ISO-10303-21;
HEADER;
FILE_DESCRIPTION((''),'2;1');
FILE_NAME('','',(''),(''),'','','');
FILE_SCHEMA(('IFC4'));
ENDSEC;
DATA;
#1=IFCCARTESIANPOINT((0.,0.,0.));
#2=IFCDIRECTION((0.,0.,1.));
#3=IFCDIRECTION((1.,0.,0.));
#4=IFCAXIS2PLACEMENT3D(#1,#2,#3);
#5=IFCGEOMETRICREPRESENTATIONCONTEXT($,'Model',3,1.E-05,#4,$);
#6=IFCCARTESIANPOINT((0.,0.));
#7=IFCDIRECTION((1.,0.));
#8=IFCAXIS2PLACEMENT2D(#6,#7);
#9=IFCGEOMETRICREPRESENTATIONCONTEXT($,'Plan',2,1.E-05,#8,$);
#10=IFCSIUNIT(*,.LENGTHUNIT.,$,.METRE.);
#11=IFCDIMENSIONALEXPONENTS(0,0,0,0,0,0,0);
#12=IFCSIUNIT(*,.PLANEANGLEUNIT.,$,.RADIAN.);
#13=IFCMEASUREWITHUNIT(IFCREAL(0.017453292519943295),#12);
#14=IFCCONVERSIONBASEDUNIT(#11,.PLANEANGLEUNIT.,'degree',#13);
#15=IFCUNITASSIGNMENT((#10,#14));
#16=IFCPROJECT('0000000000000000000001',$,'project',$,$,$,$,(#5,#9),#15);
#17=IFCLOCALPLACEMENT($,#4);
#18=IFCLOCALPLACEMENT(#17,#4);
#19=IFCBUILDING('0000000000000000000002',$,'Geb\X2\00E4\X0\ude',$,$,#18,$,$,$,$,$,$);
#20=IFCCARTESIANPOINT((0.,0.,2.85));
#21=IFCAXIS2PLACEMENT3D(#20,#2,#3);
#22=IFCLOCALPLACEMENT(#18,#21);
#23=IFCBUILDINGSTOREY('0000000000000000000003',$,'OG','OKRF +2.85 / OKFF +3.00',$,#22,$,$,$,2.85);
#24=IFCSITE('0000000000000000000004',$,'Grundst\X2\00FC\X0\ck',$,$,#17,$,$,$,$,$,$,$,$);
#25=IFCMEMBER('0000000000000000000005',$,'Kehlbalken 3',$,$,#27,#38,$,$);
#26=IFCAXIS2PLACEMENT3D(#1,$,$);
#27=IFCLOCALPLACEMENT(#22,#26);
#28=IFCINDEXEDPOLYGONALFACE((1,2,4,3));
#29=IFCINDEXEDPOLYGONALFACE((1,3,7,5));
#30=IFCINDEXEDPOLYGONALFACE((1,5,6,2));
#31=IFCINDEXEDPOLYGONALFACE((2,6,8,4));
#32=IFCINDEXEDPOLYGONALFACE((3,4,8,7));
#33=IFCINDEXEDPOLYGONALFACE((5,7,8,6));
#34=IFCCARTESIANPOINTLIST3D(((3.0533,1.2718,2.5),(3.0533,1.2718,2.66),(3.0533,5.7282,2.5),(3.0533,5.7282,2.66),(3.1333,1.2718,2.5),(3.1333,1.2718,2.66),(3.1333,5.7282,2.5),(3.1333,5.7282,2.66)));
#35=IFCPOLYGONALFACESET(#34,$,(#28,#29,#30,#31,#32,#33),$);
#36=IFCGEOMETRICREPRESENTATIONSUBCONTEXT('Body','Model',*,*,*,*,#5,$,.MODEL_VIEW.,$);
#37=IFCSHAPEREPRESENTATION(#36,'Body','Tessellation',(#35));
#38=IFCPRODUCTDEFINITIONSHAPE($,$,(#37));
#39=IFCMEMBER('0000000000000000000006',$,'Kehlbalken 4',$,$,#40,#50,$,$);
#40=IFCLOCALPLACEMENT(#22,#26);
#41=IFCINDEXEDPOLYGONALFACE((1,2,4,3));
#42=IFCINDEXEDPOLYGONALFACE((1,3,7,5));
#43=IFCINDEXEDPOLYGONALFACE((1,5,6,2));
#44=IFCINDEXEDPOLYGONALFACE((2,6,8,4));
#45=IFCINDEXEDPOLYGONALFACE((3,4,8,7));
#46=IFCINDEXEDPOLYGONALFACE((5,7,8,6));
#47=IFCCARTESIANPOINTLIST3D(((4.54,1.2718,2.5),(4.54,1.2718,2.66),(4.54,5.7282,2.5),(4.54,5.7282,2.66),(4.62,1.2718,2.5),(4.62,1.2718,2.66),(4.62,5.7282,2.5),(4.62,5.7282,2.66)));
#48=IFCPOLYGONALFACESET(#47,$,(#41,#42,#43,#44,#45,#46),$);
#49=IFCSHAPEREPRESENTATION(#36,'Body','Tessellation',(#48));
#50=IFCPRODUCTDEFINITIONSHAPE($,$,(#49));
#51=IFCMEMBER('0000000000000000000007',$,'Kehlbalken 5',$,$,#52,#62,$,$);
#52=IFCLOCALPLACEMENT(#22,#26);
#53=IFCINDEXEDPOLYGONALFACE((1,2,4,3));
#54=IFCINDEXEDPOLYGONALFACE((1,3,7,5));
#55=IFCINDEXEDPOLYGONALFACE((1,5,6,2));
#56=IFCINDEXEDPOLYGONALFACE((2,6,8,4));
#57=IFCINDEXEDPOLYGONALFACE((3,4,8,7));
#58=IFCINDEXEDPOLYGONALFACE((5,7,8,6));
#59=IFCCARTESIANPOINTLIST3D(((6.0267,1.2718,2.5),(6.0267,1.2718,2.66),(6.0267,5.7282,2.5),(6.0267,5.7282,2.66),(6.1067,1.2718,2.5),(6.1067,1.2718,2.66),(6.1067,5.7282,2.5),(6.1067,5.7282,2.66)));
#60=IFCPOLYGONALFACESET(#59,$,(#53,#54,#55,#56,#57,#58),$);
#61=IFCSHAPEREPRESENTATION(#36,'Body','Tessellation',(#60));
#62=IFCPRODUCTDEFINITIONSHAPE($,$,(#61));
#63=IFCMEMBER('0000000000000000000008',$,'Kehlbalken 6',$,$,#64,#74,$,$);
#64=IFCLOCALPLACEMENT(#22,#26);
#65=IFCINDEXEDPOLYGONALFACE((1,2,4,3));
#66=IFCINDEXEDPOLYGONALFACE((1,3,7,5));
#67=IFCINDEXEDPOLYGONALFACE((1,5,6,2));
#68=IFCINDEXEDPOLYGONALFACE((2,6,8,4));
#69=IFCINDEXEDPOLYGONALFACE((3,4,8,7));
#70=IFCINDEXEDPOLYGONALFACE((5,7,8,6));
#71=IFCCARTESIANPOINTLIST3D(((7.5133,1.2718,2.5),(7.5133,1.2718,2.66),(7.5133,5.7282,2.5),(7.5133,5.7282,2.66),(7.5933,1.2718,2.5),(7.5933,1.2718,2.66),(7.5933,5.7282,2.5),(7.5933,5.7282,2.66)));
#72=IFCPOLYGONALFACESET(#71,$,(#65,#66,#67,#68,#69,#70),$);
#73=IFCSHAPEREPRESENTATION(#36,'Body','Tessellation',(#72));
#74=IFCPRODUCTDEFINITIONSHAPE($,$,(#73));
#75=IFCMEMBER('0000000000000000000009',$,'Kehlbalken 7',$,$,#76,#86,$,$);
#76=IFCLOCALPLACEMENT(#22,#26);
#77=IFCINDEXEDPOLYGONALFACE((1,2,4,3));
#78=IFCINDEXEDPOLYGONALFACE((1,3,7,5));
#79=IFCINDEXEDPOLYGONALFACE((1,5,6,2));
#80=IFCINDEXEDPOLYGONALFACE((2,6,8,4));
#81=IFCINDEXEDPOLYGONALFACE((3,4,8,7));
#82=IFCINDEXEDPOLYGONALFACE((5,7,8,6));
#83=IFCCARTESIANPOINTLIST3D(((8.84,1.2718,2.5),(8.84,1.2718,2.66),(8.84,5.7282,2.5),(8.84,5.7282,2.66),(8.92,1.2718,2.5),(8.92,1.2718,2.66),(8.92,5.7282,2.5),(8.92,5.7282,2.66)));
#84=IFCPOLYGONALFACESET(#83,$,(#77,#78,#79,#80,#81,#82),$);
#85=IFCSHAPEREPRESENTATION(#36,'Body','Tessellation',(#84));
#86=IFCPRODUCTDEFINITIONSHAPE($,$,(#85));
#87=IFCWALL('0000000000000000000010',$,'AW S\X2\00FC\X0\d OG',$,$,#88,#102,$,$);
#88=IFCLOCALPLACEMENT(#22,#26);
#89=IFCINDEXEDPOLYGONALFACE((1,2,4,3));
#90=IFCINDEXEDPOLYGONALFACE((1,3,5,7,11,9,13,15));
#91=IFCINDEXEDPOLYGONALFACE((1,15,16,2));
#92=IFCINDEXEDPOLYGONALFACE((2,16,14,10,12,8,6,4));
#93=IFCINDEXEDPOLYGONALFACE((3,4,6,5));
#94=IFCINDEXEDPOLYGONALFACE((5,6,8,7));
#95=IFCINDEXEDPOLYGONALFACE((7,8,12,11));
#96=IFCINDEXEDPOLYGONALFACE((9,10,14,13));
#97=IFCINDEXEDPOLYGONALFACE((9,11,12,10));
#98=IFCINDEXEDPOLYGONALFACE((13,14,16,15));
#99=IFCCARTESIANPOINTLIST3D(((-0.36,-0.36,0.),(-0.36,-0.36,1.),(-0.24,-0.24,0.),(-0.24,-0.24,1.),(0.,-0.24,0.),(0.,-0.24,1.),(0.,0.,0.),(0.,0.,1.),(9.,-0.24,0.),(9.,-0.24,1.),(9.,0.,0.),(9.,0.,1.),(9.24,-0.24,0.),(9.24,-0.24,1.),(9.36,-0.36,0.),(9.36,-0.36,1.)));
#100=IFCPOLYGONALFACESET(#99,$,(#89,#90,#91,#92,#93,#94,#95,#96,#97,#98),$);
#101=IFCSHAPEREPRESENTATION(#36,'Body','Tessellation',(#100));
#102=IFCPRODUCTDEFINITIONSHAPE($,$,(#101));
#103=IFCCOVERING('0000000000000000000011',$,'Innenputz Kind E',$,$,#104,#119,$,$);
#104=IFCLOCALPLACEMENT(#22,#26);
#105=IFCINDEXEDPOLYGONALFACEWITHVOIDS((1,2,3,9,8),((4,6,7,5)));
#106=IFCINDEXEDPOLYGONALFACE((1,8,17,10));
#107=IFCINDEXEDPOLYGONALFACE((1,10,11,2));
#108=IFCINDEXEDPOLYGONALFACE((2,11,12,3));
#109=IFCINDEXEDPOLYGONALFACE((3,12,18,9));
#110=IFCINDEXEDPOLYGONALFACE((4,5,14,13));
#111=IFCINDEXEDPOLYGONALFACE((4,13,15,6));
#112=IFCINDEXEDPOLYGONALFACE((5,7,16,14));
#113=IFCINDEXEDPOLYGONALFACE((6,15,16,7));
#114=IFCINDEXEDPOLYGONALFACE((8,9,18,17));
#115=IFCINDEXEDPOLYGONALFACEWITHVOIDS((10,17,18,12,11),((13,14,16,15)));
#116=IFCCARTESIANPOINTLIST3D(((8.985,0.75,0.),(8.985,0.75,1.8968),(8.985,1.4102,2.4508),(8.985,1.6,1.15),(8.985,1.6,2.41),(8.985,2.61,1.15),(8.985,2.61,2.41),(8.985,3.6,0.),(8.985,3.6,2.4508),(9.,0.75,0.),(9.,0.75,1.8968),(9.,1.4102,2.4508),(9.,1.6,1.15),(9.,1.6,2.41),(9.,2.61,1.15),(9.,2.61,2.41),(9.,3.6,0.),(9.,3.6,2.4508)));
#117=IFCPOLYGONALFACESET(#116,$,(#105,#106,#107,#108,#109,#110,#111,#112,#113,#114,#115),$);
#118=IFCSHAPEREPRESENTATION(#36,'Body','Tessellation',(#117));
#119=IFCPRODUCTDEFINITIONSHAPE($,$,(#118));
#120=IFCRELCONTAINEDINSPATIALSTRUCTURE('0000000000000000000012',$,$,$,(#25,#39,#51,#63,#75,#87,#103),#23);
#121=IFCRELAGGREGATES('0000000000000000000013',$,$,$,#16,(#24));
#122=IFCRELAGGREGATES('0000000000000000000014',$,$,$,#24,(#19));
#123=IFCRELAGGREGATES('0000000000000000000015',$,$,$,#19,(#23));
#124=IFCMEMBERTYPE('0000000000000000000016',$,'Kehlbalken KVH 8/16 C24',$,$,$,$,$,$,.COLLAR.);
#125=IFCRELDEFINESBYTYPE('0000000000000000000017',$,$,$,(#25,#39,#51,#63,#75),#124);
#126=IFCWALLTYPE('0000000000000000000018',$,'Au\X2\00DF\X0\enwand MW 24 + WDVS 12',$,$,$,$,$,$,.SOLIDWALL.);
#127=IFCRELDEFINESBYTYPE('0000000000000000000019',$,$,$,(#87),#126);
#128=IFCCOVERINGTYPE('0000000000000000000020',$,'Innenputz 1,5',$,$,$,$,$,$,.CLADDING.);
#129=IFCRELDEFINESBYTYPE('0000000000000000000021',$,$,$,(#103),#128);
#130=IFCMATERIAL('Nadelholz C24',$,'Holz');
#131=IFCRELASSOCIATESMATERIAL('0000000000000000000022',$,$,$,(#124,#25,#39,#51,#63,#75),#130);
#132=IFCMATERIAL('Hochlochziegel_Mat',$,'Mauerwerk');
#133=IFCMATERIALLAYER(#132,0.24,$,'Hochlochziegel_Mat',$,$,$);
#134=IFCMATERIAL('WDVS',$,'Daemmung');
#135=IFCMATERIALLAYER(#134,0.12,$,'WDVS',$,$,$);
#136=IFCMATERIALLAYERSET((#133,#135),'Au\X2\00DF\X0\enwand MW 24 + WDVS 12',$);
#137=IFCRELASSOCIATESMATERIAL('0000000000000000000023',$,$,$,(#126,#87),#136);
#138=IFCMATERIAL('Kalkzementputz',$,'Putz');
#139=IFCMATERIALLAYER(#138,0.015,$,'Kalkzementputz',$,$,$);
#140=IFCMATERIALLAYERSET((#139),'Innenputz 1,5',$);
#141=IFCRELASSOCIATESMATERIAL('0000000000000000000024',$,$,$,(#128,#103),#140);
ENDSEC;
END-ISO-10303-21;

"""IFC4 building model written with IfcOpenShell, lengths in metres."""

from ifc_helpers import new_model, entity, si_unit, converted_unit, frame, origin_with_axes, origin_2d_with_axis, place, context, subcontext, project, spatial, line, indexed_curve, rectangle, outline, extrude, clip, halfspace, material, layer, layer_set, layer_usage, material_profile, profile_set, profile_usage, type_object, element, save


model = new_model("IFC4")

# Units and contexts
model_context = context("Model", 3, precision=1e-05, world=origin_with_axes())
plan_context = context("Plan", 2, precision=1e-05, world=origin_2d_with_axis())
body_context = subcontext(model_context, "Body", "Model", "MODEL_VIEW")
ifc_project = project(units=[si_unit("LENGTHUNIT", "METRE"), converted_unit("PLANEANGLEUNIT", "degree", entity("IfcReal", 0.017453292519943295), si_unit("PLANEANGLEUNIT", "RADIAN"), dimensions=[0, 0, 0, 0, 0, 0, 0])], contexts=[model_context, plan_context])

# Site, building, storey
site_placement = place(None, origin_with_axes())
site = spatial("IfcSite", under=ifc_project, at=site_placement, Name="Grundstück")
building_placement = place(site_placement, origin_with_axes())
building = spatial("IfcBuilding", under=site, at=building_placement, Name="Gebäude")
storey_placement = place(building_placement, frame((0.0, 0.0, 2.85), z_axis=(0.0, 0.0, 1.0), x_axis=(1.0, 0.0, 0.0)))
storey = spatial("IfcBuildingStorey", under=building, at=storey_placement, Name="OG", Description="OKRF +2.85 / OKFF +3.00", Elevation=2.85)

# Members
ifc_material_1 = material(Name="Nadelholz C24", Category="Holz")
ifc_material_profile_1 = material_profile(ifc_material_1, rectangle(XDim=0.08, YDim=0.16))
ifc_profile_set_1 = profile_set([ifc_material_profile_1], Name="Kehlbalken KVH 8/16 C24")
ifc_profile_usage_1 = profile_usage(ifc_profile_set_1)
member_type_1 = type_object("IfcMemberType", Name="Kehlbalken KVH 8/16 C24", PredefinedType="COLLAR", material=ifc_profile_set_1)
member_1_placement = place(storey_placement, frame((3.0933, 1.2718, 2.58), z_axis=(0.0, 1.0, 0.0), x_axis=(-1.0, 0.0, 0.0)))
element("IfcMember", 1, at=member_1_placement, inside=storey, type_object=member_type_1, material=ifc_profile_usage_1, Name="Kehlbalken 3", context=body_context, shape_type="SweptSolid", body=[
    extrude(rectangle(XDim=0.08, YDim=0.16), origin_with_axes(), (0.0, 0.0, 1.0), 4.4564),
])
ifc_profile_usage_2 = profile_usage(ifc_profile_set_1)
member_2_placement = place(storey_placement, frame((4.58, 1.2718, 2.58), z_axis=(0.0, 1.0, 0.0), x_axis=(-1.0, 0.0, 0.0)))
element("IfcMember", 2, at=member_2_placement, inside=storey, type_object=member_type_1, material=ifc_profile_usage_2, Name="Kehlbalken 4", context=body_context, shape_type="SweptSolid", body=[
    extrude(rectangle(XDim=0.08, YDim=0.16), origin_with_axes(), (0.0, 0.0, 1.0), 4.4564),
])
ifc_profile_usage_3 = profile_usage(ifc_profile_set_1)
member_3_placement = place(storey_placement, frame((6.0667, 1.2718, 2.58), z_axis=(0.0, 1.0, 0.0), x_axis=(-1.0, 0.0, 0.0)))
element("IfcMember", 3, at=member_3_placement, inside=storey, type_object=member_type_1, material=ifc_profile_usage_3, Name="Kehlbalken 5", context=body_context, shape_type="SweptSolid", body=[
    extrude(rectangle(XDim=0.08, YDim=0.16), origin_with_axes(), (0.0, 0.0, 1.0), 4.4564),
])
ifc_profile_usage_4 = profile_usage(ifc_profile_set_1)
member_4_placement = place(storey_placement, frame((7.5533, 1.2718, 2.58), z_axis=(0.0, 1.0, 0.0), x_axis=(-1.0, 0.0, 0.0)))
element("IfcMember", 4, at=member_4_placement, inside=storey, type_object=member_type_1, material=ifc_profile_usage_4, Name="Kehlbalken 6", context=body_context, shape_type="SweptSolid", body=[
    extrude(rectangle(XDim=0.08, YDim=0.16), origin_with_axes(), (0.0, 0.0, 1.0), 4.4564),
])
ifc_profile_usage_5 = profile_usage(ifc_profile_set_1)
member_5_placement = place(storey_placement, frame((8.88, 1.2718, 2.58), z_axis=(0.0, 1.0, 0.0), x_axis=(-1.0, 0.0, 0.0)))
element("IfcMember", 5, at=member_5_placement, inside=storey, type_object=member_type_1, material=ifc_profile_usage_5, Name="Kehlbalken 7", context=body_context, shape_type="SweptSolid", body=[
    extrude(rectangle(XDim=0.08, YDim=0.16), origin_with_axes(), (0.0, 0.0, 1.0), 4.4564),
])

# Wall
ifc_material_2 = material(Name="Hochlochziegel_Mat", Category="Mauerwerk")
ifc_layer_1 = layer(ifc_material_2, 0.24, Name="Hochlochziegel_Mat")
ifc_material_3 = material(Name="WDVS", Category="Daemmung")
ifc_layer_2 = layer(ifc_material_3, 0.12, Name="WDVS")
ifc_layer_set_1 = layer_set([ifc_layer_1, ifc_layer_2], Name="Außenwand MW 24 + WDVS 12")
ifc_layer_usage_1 = layer_usage(ifc_layer_set_1, "AXIS2", "POSITIVE", 0.0)
wall_type = type_object("IfcWallType", Name="Außenwand MW 24 + WDVS 12", PredefinedType="SOLIDWALL", material=ifc_layer_set_1)
wall_placement = place(storey_placement, frame((9.0, 0.0, 0.0), z_axis=(0.0, 0.0, 1.0), x_axis=(-1.0, 0.0, 0.0)))
element("IfcWall", 6, at=wall_placement, inside=storey, type_object=wall_type, material=ifc_layer_usage_1, Name="AW Süd OG", context=body_context, shape_type="SweptSolid", body=[
    extrude(outline(indexed_curve([(0.0, 0.0), (0.0, 0.24), (-0.24, 0.24), (-0.36, 0.36), (9.36, 0.36), (9.24, 0.24), (9.0, 0.24), (9.0, 0.0)], segments=[line(1, 2, 3, 4, 5, 6, 7, 8, 1)])), origin_with_axes(), (0.0, 0.0, 1.0), 1.0),
])

# Covering, opening
ifc_material_4 = material(Name="Kalkzementputz", Category="Putz")
ifc_layer_3 = layer(ifc_material_4, 0.015, Name="Kalkzementputz")
ifc_layer_set_2 = layer_set([ifc_layer_3], Name="Innenputz 1,5")
ifc_layer_usage_2 = layer_usage(ifc_layer_set_2, "AXIS2", "POSITIVE", 0.0)
covering_type_1 = type_object("IfcCoveringType", Name="Innenputz 1,5", PredefinedType="CLADDING", material=ifc_layer_set_2)
covering_1_placement = place(storey_placement, frame((9.0, 0.75, 0.0), z_axis=(0.0, 0.0, 1.0), x_axis=(0.0, 1.0, 0.0)))
covering_1 = element("IfcCovering", 7, at=covering_1_placement, inside=storey, type_object=covering_type_1, material=ifc_layer_usage_2, Name="Innenputz Kind E", context=body_context, shape_type="Clipping", body=[
    clip(clip(extrude(outline(indexed_curve([(0.0, 0.0), (0.0, 0.015), (2.85, 0.015), (2.85, 0.0), (0.0, 0.0)], self_intersect=False)), origin_with_axes(), (0.0, 0.0, 1.0), 2.4508), halfspace(frame((-0.99, 9.0, 1.0661), z_axis=(-0.642788, 0.0, 0.766044), x_axis=(0.0, 1.0, 0.0)), False)), halfspace(frame((6.49, 9.0, 1.0661), z_axis=(0.642788, 0.0, 0.766044), x_axis=(0.0, -1.0, 0.0)), False)),
])
opening_1_placement = place(covering_1_placement, frame((0.85, -0.05, 1.15), z_axis=(0.0, 0.0, 1.0), x_axis=(1.0, 0.0, 0.0)))
element("IfcOpeningElement", 8, at=opening_1_placement, cuts=covering_1, context=body_context, shape_type="SweptSolid", body=[
    extrude(outline(indexed_curve([(0.0, 0.0), (0.0, 0.115), (1.01, 0.115), (1.01, 0.0), (0.0, 0.0)], self_intersect=False)), origin_with_axes(), (0.0, 0.0, 1.0), 1.26),
])

save(model, "model.ifc")
